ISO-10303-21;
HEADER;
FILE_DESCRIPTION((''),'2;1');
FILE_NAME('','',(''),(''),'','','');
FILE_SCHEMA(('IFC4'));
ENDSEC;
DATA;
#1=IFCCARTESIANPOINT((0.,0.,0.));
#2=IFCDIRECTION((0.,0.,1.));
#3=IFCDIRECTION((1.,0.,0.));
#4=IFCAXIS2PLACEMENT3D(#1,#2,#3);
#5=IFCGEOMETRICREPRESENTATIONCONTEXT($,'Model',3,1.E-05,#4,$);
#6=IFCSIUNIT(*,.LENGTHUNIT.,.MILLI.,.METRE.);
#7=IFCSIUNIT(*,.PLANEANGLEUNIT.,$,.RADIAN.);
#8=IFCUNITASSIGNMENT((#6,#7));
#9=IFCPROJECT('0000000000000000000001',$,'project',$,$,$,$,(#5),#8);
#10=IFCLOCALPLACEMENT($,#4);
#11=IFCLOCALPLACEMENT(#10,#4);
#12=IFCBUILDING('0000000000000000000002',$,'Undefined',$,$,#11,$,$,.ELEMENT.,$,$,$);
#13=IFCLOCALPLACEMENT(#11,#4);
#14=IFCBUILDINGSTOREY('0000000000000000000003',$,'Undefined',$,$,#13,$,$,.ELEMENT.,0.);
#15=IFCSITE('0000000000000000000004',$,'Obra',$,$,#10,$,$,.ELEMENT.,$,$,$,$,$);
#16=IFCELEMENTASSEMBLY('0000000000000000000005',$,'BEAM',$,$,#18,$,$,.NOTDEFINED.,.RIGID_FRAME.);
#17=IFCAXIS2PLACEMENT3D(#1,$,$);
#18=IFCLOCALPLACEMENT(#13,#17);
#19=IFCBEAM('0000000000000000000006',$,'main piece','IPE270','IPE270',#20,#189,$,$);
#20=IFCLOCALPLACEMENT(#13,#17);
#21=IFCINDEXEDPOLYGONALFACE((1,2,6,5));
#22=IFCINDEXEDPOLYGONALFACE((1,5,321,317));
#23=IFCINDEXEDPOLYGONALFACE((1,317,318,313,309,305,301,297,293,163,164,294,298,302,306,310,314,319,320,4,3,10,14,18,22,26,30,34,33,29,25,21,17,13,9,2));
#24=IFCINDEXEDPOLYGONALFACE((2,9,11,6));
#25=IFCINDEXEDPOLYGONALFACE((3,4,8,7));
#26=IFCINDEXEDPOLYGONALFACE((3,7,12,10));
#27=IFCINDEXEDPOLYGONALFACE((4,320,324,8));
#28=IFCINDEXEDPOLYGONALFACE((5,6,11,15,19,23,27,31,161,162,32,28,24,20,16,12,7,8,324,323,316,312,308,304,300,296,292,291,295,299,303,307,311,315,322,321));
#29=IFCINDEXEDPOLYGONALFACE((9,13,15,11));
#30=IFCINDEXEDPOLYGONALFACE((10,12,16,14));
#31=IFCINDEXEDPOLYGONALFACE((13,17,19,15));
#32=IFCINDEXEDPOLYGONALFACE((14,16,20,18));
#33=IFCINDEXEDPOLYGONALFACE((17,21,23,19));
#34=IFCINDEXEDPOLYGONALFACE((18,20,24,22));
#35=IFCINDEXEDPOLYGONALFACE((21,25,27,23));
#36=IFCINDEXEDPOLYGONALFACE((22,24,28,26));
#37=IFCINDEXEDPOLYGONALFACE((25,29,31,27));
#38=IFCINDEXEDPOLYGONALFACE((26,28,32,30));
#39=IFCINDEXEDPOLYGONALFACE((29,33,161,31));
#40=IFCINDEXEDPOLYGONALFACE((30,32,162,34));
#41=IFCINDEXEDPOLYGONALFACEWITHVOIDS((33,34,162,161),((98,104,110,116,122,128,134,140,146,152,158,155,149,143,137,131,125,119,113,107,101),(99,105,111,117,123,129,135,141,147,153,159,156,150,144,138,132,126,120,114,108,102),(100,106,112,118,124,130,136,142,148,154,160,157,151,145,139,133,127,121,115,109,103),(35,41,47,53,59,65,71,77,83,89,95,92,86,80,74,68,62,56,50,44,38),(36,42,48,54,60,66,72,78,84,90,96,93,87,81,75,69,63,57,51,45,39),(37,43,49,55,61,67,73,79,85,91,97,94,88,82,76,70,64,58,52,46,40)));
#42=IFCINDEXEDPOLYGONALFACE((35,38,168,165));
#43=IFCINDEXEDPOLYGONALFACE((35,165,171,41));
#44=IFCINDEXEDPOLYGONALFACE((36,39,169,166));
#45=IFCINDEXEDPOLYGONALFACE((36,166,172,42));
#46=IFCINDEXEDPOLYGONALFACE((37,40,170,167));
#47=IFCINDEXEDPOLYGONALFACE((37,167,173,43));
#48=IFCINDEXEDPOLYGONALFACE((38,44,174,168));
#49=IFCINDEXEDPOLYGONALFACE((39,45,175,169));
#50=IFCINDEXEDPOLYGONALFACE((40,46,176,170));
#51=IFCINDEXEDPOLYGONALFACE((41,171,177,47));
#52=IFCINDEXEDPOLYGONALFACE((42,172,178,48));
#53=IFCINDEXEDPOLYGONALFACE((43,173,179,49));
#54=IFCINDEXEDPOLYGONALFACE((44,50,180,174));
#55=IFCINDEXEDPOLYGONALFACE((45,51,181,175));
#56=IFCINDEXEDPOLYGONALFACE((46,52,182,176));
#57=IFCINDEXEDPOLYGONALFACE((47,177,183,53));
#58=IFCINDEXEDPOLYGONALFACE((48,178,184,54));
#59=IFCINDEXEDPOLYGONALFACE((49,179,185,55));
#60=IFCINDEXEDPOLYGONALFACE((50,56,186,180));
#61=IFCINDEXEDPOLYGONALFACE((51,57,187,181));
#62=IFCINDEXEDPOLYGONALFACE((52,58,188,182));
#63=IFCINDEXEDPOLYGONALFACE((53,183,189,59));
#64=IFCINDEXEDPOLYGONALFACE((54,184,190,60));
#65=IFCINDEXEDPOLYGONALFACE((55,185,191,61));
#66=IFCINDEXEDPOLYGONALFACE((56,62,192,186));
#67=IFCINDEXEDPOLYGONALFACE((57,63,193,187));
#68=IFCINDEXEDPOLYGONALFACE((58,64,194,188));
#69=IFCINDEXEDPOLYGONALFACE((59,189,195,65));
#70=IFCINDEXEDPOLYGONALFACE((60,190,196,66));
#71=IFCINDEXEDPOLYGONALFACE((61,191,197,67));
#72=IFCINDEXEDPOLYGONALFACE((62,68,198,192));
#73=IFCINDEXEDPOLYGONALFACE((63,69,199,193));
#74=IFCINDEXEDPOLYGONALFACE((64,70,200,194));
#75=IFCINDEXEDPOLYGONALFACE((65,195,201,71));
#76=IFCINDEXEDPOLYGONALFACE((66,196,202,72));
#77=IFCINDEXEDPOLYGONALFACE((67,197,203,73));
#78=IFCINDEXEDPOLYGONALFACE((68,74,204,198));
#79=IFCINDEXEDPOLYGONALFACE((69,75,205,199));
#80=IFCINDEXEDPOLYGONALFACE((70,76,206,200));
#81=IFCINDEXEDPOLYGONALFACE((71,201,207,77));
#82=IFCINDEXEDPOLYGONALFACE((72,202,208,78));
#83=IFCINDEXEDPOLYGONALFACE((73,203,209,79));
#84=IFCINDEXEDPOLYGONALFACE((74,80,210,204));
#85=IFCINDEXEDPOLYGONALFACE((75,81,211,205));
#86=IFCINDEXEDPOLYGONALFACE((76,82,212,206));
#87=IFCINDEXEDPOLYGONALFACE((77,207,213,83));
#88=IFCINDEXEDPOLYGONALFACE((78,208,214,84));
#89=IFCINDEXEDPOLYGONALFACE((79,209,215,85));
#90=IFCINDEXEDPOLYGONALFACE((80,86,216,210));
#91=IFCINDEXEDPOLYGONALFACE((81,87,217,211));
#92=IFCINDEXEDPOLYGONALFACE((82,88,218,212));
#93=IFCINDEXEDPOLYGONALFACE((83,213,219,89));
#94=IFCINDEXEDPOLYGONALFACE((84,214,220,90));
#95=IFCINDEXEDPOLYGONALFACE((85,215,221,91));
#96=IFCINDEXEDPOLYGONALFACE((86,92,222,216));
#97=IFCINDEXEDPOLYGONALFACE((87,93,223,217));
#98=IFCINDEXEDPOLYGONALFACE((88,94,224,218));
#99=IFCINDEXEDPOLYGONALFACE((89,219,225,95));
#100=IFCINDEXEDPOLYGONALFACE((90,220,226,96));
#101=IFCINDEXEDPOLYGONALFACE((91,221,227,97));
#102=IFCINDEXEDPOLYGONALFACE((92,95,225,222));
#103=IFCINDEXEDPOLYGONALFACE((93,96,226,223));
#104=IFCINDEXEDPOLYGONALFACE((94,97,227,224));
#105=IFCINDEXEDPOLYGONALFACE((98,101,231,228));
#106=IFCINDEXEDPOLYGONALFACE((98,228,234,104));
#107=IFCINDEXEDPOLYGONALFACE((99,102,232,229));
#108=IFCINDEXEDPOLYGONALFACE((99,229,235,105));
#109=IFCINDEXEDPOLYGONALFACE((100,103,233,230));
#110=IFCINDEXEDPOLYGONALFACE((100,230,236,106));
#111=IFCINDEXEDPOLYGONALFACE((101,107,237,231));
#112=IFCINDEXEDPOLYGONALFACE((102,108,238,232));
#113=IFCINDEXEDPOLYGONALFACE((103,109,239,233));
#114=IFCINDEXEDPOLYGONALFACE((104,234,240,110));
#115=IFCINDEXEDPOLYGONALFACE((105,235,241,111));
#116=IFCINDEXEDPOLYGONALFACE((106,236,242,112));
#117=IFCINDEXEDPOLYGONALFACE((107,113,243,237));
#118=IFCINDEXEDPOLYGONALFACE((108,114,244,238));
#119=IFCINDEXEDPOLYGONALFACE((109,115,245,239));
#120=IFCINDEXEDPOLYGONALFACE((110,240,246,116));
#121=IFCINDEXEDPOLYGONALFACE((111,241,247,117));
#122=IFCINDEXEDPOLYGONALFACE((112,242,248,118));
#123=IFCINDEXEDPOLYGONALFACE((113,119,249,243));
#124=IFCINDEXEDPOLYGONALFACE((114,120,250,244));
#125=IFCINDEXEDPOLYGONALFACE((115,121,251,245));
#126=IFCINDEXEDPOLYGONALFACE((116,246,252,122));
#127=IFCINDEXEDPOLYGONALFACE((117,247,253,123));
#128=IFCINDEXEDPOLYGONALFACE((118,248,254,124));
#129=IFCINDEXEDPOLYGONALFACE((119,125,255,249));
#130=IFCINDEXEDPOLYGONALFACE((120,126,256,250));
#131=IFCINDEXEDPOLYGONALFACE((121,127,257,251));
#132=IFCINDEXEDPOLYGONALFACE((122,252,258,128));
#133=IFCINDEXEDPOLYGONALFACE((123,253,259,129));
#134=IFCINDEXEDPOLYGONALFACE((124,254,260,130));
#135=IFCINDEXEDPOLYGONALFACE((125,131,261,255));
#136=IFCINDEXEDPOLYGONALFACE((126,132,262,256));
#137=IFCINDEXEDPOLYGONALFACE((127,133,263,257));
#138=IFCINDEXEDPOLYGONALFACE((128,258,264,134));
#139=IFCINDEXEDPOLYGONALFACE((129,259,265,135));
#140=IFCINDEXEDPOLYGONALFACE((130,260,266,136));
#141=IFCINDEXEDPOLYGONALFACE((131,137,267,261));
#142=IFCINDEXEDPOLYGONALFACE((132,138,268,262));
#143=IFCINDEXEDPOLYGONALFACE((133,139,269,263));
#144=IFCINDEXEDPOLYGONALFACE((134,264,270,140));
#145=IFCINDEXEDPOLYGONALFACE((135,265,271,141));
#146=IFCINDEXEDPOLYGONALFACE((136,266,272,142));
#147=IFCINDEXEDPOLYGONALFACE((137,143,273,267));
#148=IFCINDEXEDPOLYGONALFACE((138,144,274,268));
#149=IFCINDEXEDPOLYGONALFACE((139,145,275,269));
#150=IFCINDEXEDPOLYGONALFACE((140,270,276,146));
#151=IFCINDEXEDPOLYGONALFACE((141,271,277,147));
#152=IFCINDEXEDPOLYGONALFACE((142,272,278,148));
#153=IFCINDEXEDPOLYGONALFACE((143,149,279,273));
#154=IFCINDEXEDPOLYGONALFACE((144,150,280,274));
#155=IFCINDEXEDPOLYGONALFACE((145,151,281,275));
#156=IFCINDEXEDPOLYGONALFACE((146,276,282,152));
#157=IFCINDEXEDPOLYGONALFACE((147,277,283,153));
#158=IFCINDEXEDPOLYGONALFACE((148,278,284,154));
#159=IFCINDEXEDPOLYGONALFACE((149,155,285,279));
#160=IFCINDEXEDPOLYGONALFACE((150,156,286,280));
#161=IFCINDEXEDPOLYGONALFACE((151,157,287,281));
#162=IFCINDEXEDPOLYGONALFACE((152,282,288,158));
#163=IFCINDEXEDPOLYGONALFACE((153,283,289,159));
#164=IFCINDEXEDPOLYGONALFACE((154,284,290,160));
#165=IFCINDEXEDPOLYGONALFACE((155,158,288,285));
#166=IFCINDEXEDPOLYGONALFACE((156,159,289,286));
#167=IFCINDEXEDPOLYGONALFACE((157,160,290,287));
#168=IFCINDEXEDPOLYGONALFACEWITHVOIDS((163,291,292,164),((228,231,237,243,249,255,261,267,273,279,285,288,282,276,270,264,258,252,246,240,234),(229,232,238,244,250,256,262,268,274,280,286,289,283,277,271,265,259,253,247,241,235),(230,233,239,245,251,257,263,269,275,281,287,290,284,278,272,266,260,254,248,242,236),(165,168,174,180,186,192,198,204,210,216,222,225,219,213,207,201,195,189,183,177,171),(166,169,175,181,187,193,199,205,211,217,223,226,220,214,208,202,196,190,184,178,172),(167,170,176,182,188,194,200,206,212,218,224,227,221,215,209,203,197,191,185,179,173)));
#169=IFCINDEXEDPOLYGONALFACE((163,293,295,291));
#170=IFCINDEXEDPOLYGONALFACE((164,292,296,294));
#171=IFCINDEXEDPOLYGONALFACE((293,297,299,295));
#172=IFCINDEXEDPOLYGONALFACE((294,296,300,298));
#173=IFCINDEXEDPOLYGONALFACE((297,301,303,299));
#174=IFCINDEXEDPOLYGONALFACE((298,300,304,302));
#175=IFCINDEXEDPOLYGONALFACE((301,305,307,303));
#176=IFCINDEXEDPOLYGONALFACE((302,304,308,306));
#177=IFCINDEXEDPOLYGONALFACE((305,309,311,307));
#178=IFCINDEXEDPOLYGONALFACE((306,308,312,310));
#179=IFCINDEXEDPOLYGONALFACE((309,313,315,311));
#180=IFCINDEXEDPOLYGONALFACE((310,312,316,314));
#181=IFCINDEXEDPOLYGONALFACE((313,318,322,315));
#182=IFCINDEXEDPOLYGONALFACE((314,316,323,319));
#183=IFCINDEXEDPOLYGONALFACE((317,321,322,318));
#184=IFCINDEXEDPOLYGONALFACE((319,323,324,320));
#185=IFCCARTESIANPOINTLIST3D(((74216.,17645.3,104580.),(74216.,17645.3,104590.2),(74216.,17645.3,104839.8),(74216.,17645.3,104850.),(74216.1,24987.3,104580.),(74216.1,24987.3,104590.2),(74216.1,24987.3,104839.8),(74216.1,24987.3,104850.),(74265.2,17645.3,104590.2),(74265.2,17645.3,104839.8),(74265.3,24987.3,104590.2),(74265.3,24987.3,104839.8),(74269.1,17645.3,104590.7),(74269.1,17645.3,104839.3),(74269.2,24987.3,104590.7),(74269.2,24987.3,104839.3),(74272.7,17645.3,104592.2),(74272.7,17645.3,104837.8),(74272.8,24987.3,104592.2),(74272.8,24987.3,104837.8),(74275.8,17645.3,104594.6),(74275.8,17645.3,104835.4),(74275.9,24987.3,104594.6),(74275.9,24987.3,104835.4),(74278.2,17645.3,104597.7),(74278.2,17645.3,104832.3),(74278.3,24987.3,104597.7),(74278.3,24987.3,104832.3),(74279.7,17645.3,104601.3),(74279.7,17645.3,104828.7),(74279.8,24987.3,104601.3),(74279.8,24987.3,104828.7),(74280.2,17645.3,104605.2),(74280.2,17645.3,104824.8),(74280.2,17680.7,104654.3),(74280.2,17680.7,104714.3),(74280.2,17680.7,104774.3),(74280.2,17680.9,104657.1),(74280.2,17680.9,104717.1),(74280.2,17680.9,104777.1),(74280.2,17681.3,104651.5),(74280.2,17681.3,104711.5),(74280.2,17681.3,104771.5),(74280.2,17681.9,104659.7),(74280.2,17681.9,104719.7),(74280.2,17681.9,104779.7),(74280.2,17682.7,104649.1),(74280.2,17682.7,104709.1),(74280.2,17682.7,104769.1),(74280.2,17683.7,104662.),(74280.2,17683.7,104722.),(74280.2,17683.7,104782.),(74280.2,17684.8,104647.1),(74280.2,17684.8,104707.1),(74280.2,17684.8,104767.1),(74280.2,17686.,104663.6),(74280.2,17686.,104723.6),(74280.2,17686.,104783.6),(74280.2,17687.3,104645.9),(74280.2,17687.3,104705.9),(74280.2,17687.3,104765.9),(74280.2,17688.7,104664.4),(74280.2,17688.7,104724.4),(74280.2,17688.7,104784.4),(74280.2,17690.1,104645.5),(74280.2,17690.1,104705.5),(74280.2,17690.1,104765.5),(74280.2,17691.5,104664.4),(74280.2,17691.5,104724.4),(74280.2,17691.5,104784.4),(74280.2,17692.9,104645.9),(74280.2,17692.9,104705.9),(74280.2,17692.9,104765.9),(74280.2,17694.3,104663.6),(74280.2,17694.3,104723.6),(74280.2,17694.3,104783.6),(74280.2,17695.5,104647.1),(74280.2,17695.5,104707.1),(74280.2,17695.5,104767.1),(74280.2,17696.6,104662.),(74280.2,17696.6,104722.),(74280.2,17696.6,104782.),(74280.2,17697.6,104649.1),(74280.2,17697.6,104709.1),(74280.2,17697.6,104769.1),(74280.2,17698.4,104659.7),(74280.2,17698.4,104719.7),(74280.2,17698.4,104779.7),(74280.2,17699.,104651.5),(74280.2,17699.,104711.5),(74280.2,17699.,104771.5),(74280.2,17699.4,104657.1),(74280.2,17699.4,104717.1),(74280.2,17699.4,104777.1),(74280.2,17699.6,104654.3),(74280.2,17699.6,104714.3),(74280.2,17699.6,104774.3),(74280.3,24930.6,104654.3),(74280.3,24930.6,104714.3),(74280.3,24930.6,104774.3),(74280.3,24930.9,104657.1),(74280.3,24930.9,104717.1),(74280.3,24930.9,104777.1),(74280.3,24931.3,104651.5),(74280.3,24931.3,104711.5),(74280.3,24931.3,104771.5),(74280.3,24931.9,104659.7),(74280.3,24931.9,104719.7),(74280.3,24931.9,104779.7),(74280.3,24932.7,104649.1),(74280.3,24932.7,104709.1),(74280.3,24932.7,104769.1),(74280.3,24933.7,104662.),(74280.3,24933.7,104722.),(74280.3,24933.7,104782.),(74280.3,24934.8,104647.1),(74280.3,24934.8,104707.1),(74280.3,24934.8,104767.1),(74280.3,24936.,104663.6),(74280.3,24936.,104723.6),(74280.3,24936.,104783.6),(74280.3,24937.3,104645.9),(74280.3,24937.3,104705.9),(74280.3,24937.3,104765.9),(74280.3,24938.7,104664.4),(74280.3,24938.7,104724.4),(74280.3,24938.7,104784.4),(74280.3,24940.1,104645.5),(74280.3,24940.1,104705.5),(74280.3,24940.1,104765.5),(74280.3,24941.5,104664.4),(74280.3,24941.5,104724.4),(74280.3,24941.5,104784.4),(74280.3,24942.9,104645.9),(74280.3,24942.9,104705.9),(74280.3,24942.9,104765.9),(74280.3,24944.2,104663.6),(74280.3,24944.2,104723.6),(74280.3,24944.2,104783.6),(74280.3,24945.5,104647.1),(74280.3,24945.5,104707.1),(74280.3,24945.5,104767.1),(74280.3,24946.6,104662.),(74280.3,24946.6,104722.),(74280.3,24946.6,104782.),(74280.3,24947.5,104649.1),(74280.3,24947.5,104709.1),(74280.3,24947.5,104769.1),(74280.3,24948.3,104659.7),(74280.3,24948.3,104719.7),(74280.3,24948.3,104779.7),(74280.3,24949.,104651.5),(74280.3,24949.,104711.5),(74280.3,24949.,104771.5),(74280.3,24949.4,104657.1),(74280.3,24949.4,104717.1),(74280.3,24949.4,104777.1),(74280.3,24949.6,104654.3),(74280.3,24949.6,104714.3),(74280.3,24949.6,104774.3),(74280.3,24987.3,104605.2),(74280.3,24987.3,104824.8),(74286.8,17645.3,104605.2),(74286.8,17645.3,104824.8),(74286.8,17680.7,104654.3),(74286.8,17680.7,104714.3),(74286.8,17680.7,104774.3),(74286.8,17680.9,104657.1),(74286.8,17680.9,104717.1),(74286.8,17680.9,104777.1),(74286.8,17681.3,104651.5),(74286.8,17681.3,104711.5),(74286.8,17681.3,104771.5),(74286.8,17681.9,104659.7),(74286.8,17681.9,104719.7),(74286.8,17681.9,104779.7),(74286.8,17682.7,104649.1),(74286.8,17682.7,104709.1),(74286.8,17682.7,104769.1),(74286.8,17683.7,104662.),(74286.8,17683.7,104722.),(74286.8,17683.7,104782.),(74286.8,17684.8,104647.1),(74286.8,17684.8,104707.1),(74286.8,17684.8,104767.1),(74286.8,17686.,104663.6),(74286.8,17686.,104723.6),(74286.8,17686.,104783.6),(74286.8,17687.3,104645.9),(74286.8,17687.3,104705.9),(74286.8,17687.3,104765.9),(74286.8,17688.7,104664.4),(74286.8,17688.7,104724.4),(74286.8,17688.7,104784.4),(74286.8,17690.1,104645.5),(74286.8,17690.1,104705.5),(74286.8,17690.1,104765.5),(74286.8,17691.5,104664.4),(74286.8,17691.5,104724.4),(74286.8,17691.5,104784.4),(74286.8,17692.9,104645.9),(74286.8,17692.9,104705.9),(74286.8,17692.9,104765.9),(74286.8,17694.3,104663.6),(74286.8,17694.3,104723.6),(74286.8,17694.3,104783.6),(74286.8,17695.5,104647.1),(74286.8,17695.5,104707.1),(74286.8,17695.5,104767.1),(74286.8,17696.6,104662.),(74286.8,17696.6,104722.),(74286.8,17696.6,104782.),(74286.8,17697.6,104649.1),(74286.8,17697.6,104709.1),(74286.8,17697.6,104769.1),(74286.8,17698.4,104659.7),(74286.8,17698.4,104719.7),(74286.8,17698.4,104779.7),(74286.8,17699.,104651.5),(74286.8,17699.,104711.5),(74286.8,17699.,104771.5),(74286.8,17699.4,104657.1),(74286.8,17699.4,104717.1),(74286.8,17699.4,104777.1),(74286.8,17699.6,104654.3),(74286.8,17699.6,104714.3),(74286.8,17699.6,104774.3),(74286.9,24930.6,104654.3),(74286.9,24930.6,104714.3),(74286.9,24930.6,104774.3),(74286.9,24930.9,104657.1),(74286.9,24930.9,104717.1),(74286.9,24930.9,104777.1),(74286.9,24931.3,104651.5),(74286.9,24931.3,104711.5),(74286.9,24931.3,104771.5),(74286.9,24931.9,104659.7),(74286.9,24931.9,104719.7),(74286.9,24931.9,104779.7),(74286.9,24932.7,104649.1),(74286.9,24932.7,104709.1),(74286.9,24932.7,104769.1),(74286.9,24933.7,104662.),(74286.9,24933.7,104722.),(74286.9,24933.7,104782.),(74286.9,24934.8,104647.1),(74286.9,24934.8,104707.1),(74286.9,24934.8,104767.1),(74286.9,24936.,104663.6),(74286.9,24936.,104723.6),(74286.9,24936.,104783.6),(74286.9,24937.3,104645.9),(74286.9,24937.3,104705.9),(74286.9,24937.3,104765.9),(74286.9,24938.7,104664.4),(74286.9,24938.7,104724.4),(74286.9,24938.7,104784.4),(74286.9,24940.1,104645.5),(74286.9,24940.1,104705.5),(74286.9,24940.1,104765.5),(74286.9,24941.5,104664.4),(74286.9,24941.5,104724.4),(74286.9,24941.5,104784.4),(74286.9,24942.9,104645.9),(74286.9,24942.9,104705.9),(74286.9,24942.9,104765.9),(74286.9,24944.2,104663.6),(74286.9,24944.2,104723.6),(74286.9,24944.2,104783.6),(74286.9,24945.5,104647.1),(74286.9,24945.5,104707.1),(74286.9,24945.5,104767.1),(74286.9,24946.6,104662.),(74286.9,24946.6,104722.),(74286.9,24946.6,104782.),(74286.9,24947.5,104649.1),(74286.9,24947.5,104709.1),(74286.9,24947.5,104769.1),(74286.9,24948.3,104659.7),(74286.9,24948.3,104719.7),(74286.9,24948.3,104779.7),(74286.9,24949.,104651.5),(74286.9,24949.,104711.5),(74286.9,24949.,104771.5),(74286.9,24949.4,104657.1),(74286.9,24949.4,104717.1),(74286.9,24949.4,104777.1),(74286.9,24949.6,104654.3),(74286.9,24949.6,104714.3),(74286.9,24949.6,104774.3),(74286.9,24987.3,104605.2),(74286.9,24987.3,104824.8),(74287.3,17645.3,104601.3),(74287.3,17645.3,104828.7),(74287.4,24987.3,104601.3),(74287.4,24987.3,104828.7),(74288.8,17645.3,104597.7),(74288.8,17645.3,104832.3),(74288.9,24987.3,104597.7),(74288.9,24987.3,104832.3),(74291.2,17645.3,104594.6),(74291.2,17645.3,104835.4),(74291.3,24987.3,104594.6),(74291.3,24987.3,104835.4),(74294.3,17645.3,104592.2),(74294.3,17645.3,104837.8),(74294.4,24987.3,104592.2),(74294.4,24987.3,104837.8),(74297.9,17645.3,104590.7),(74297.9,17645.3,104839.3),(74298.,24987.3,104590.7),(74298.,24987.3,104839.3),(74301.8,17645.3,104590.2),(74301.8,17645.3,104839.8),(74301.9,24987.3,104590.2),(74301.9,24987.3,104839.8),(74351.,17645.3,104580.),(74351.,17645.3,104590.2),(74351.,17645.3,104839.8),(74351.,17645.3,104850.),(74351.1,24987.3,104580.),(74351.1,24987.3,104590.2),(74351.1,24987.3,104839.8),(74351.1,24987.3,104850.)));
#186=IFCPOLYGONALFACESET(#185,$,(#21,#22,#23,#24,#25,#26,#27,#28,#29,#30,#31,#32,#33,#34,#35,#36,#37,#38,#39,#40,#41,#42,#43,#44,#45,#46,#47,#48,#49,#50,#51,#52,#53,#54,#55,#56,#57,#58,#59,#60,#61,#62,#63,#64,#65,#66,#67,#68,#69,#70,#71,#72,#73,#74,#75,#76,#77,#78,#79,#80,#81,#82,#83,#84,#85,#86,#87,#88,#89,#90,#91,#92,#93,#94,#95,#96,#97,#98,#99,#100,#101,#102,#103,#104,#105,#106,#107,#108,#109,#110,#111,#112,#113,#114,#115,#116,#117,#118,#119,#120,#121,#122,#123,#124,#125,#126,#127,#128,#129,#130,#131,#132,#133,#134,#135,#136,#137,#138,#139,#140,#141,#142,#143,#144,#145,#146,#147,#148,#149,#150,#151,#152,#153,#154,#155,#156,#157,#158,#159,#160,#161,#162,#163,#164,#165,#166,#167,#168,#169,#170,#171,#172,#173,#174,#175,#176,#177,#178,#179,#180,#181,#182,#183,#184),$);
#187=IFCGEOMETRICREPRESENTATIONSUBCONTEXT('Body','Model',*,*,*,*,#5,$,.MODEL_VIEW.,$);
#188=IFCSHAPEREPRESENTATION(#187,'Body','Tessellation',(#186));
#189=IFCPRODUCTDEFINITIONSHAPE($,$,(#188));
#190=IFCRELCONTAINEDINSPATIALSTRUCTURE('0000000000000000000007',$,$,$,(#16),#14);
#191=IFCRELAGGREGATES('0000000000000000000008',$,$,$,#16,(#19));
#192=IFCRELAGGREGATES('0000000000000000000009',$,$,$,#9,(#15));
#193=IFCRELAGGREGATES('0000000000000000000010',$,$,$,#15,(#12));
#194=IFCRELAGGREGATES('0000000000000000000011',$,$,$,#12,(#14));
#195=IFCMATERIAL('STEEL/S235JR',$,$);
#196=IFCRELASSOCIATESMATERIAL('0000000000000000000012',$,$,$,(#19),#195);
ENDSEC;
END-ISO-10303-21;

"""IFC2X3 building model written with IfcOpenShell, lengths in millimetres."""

from ifc_helpers import new_model, si_unit, frame, origin_with_axes, origin_2d_with_axis, place, context, subcontext, project, spatial, circle, i_section, extrude, clip, halfspace, source, transform, mapped, material, element, aggregate, save


model = new_model("IFC2X3")

# Units and contexts
model_context = context("Model", 3, precision=1e-05, world=origin_with_axes())
body_context = subcontext(model_context, "Body", "Model", "MODEL_VIEW")
ifc_project = project(units=[si_unit("LENGTHUNIT", "METRE", prefix="MILLI"), si_unit("PLANEANGLEUNIT", "RADIAN")], contexts=[model_context])

# Site, building, storey
site_placement = place(None, origin_with_axes())
site = spatial("IfcSite", under=ifc_project, at=site_placement, Name="Obra", CompositionType="ELEMENT")
building_placement = place(site_placement, origin_with_axes())
building = spatial("IfcBuilding", under=site, at=building_placement, Name="Undefined", CompositionType="ELEMENT")
storey_placement = place(building_placement, origin_with_axes())
storey = spatial("IfcBuildingStorey", under=building, at=storey_placement, Name="Undefined", CompositionType="ELEMENT", Elevation=0.0)

# Shared definitions
ifc_material = material(Name="STEEL/S235JR")

# Element assembly, beam, openings
assembly_1_placement = place(storey_placement, origin_with_axes())
assembly_1 = element("IfcElementAssembly", 1, at=assembly_1_placement, inside=storey, Name="BEAM", AssemblyPlace="NOTDEFINED", PredefinedType="RIGID_FRAME")
beam_1_placement = place(assembly_1_placement, frame((74283.5, 17645.3, 104715.0), z_axis=(0.0, 0.0, 1.0), x_axis=(0.000013, 1.0, 0.0)))
beam_1 = element("IfcBeam", 2, at=beam_1_placement, material=ifc_material, Name="main piece", Description="IPE270", ObjectType="IPE270", context=body_context, shape_type="Clipping", body=[
    clip(clip(extrude(i_section(OverallWidth=135.0, OverallDepth=270.0, WebThickness=6.6, FlangeThickness=10.2, FilletRadius=15.0, at=origin_2d_with_axis()), frame((7342.1, 0.0, 0.0), z_axis=(-1.0, 0.0, 0.0), x_axis=(0.0, -1.0, 0.0)), (0.0, 0.0, 1.0), 7342.1), halfspace(frame((-4.7, 60.0, -120.0), z_axis=(-1.0, -0.000032, 0.0), x_axis=(0.0, 0.0, 1.0)), False)), halfspace(frame((7344.4, -60.0, -120.0), z_axis=(1.0, 0.000034, 0.0), x_axis=(0.0, 0.0, 1.0)), False)),
])
shared_shape_1 = source(origin_with_axes(), body_context, "Body", "SweptSolid", [
    extrude(circle(Radius=9.5, at=origin_2d_with_axis()), frame((0.0, -3.4, 0.0), z_axis=(0.0, 1.0, 0.0), x_axis=(1.0, 0.0, 0.0)), (0.0, 0.0, 1.0), 6.8),
])
opening_1_placement = place(assembly_1_placement, frame((74283.5, 17640.1, 104835.0), z_axis=(0.0, 1.0, 0.0), x_axis=(0.0, 0.0, -1.0)))
element("IfcOpeningElement", 3, at=opening_1_placement, cuts=beam_1, ObjectType="Opening", context=body_context, shape_type="MappedRepresentation", body=[
    mapped(shared_shape_1, transform((60.0, 0.0, 50.0))),
    mapped(shared_shape_1, transform((120.0, 0.0, 50.0))),
    mapped(shared_shape_1, transform((180.0, 0.0, 50.0))),
])
shared_shape_2 = source(origin_with_axes(), body_context, "Body", "SweptSolid", [
    extrude(circle(Radius=9.5, at=origin_2d_with_axis()), frame((0.0, -3.4, 0.0), z_axis=(0.0, 1.0, 0.0), x_axis=(1.0, 0.0, 0.0)), (0.0, 0.0, 1.0), 6.8),
])
opening_2_placement = place(assembly_1_placement, frame((74283.6, 24990.1, 104835.0), z_axis=(0.000002, -1.0, 0.0), x_axis=(0.0, 0.0, -1.0)))
element("IfcOpeningElement", 4, at=opening_2_placement, cuts=beam_1, ObjectType="Opening", context=body_context, shape_type="MappedRepresentation", body=[
    mapped(shared_shape_2, transform((60.0, 0.0, 50.0))),
    mapped(shared_shape_2, transform((120.0, 0.0, 50.0))),
    mapped(shared_shape_2, transform((180.0, 0.0, 50.0))),
])
aggregate(assembly_1, [beam_1])

save(model, "model.ifc")
